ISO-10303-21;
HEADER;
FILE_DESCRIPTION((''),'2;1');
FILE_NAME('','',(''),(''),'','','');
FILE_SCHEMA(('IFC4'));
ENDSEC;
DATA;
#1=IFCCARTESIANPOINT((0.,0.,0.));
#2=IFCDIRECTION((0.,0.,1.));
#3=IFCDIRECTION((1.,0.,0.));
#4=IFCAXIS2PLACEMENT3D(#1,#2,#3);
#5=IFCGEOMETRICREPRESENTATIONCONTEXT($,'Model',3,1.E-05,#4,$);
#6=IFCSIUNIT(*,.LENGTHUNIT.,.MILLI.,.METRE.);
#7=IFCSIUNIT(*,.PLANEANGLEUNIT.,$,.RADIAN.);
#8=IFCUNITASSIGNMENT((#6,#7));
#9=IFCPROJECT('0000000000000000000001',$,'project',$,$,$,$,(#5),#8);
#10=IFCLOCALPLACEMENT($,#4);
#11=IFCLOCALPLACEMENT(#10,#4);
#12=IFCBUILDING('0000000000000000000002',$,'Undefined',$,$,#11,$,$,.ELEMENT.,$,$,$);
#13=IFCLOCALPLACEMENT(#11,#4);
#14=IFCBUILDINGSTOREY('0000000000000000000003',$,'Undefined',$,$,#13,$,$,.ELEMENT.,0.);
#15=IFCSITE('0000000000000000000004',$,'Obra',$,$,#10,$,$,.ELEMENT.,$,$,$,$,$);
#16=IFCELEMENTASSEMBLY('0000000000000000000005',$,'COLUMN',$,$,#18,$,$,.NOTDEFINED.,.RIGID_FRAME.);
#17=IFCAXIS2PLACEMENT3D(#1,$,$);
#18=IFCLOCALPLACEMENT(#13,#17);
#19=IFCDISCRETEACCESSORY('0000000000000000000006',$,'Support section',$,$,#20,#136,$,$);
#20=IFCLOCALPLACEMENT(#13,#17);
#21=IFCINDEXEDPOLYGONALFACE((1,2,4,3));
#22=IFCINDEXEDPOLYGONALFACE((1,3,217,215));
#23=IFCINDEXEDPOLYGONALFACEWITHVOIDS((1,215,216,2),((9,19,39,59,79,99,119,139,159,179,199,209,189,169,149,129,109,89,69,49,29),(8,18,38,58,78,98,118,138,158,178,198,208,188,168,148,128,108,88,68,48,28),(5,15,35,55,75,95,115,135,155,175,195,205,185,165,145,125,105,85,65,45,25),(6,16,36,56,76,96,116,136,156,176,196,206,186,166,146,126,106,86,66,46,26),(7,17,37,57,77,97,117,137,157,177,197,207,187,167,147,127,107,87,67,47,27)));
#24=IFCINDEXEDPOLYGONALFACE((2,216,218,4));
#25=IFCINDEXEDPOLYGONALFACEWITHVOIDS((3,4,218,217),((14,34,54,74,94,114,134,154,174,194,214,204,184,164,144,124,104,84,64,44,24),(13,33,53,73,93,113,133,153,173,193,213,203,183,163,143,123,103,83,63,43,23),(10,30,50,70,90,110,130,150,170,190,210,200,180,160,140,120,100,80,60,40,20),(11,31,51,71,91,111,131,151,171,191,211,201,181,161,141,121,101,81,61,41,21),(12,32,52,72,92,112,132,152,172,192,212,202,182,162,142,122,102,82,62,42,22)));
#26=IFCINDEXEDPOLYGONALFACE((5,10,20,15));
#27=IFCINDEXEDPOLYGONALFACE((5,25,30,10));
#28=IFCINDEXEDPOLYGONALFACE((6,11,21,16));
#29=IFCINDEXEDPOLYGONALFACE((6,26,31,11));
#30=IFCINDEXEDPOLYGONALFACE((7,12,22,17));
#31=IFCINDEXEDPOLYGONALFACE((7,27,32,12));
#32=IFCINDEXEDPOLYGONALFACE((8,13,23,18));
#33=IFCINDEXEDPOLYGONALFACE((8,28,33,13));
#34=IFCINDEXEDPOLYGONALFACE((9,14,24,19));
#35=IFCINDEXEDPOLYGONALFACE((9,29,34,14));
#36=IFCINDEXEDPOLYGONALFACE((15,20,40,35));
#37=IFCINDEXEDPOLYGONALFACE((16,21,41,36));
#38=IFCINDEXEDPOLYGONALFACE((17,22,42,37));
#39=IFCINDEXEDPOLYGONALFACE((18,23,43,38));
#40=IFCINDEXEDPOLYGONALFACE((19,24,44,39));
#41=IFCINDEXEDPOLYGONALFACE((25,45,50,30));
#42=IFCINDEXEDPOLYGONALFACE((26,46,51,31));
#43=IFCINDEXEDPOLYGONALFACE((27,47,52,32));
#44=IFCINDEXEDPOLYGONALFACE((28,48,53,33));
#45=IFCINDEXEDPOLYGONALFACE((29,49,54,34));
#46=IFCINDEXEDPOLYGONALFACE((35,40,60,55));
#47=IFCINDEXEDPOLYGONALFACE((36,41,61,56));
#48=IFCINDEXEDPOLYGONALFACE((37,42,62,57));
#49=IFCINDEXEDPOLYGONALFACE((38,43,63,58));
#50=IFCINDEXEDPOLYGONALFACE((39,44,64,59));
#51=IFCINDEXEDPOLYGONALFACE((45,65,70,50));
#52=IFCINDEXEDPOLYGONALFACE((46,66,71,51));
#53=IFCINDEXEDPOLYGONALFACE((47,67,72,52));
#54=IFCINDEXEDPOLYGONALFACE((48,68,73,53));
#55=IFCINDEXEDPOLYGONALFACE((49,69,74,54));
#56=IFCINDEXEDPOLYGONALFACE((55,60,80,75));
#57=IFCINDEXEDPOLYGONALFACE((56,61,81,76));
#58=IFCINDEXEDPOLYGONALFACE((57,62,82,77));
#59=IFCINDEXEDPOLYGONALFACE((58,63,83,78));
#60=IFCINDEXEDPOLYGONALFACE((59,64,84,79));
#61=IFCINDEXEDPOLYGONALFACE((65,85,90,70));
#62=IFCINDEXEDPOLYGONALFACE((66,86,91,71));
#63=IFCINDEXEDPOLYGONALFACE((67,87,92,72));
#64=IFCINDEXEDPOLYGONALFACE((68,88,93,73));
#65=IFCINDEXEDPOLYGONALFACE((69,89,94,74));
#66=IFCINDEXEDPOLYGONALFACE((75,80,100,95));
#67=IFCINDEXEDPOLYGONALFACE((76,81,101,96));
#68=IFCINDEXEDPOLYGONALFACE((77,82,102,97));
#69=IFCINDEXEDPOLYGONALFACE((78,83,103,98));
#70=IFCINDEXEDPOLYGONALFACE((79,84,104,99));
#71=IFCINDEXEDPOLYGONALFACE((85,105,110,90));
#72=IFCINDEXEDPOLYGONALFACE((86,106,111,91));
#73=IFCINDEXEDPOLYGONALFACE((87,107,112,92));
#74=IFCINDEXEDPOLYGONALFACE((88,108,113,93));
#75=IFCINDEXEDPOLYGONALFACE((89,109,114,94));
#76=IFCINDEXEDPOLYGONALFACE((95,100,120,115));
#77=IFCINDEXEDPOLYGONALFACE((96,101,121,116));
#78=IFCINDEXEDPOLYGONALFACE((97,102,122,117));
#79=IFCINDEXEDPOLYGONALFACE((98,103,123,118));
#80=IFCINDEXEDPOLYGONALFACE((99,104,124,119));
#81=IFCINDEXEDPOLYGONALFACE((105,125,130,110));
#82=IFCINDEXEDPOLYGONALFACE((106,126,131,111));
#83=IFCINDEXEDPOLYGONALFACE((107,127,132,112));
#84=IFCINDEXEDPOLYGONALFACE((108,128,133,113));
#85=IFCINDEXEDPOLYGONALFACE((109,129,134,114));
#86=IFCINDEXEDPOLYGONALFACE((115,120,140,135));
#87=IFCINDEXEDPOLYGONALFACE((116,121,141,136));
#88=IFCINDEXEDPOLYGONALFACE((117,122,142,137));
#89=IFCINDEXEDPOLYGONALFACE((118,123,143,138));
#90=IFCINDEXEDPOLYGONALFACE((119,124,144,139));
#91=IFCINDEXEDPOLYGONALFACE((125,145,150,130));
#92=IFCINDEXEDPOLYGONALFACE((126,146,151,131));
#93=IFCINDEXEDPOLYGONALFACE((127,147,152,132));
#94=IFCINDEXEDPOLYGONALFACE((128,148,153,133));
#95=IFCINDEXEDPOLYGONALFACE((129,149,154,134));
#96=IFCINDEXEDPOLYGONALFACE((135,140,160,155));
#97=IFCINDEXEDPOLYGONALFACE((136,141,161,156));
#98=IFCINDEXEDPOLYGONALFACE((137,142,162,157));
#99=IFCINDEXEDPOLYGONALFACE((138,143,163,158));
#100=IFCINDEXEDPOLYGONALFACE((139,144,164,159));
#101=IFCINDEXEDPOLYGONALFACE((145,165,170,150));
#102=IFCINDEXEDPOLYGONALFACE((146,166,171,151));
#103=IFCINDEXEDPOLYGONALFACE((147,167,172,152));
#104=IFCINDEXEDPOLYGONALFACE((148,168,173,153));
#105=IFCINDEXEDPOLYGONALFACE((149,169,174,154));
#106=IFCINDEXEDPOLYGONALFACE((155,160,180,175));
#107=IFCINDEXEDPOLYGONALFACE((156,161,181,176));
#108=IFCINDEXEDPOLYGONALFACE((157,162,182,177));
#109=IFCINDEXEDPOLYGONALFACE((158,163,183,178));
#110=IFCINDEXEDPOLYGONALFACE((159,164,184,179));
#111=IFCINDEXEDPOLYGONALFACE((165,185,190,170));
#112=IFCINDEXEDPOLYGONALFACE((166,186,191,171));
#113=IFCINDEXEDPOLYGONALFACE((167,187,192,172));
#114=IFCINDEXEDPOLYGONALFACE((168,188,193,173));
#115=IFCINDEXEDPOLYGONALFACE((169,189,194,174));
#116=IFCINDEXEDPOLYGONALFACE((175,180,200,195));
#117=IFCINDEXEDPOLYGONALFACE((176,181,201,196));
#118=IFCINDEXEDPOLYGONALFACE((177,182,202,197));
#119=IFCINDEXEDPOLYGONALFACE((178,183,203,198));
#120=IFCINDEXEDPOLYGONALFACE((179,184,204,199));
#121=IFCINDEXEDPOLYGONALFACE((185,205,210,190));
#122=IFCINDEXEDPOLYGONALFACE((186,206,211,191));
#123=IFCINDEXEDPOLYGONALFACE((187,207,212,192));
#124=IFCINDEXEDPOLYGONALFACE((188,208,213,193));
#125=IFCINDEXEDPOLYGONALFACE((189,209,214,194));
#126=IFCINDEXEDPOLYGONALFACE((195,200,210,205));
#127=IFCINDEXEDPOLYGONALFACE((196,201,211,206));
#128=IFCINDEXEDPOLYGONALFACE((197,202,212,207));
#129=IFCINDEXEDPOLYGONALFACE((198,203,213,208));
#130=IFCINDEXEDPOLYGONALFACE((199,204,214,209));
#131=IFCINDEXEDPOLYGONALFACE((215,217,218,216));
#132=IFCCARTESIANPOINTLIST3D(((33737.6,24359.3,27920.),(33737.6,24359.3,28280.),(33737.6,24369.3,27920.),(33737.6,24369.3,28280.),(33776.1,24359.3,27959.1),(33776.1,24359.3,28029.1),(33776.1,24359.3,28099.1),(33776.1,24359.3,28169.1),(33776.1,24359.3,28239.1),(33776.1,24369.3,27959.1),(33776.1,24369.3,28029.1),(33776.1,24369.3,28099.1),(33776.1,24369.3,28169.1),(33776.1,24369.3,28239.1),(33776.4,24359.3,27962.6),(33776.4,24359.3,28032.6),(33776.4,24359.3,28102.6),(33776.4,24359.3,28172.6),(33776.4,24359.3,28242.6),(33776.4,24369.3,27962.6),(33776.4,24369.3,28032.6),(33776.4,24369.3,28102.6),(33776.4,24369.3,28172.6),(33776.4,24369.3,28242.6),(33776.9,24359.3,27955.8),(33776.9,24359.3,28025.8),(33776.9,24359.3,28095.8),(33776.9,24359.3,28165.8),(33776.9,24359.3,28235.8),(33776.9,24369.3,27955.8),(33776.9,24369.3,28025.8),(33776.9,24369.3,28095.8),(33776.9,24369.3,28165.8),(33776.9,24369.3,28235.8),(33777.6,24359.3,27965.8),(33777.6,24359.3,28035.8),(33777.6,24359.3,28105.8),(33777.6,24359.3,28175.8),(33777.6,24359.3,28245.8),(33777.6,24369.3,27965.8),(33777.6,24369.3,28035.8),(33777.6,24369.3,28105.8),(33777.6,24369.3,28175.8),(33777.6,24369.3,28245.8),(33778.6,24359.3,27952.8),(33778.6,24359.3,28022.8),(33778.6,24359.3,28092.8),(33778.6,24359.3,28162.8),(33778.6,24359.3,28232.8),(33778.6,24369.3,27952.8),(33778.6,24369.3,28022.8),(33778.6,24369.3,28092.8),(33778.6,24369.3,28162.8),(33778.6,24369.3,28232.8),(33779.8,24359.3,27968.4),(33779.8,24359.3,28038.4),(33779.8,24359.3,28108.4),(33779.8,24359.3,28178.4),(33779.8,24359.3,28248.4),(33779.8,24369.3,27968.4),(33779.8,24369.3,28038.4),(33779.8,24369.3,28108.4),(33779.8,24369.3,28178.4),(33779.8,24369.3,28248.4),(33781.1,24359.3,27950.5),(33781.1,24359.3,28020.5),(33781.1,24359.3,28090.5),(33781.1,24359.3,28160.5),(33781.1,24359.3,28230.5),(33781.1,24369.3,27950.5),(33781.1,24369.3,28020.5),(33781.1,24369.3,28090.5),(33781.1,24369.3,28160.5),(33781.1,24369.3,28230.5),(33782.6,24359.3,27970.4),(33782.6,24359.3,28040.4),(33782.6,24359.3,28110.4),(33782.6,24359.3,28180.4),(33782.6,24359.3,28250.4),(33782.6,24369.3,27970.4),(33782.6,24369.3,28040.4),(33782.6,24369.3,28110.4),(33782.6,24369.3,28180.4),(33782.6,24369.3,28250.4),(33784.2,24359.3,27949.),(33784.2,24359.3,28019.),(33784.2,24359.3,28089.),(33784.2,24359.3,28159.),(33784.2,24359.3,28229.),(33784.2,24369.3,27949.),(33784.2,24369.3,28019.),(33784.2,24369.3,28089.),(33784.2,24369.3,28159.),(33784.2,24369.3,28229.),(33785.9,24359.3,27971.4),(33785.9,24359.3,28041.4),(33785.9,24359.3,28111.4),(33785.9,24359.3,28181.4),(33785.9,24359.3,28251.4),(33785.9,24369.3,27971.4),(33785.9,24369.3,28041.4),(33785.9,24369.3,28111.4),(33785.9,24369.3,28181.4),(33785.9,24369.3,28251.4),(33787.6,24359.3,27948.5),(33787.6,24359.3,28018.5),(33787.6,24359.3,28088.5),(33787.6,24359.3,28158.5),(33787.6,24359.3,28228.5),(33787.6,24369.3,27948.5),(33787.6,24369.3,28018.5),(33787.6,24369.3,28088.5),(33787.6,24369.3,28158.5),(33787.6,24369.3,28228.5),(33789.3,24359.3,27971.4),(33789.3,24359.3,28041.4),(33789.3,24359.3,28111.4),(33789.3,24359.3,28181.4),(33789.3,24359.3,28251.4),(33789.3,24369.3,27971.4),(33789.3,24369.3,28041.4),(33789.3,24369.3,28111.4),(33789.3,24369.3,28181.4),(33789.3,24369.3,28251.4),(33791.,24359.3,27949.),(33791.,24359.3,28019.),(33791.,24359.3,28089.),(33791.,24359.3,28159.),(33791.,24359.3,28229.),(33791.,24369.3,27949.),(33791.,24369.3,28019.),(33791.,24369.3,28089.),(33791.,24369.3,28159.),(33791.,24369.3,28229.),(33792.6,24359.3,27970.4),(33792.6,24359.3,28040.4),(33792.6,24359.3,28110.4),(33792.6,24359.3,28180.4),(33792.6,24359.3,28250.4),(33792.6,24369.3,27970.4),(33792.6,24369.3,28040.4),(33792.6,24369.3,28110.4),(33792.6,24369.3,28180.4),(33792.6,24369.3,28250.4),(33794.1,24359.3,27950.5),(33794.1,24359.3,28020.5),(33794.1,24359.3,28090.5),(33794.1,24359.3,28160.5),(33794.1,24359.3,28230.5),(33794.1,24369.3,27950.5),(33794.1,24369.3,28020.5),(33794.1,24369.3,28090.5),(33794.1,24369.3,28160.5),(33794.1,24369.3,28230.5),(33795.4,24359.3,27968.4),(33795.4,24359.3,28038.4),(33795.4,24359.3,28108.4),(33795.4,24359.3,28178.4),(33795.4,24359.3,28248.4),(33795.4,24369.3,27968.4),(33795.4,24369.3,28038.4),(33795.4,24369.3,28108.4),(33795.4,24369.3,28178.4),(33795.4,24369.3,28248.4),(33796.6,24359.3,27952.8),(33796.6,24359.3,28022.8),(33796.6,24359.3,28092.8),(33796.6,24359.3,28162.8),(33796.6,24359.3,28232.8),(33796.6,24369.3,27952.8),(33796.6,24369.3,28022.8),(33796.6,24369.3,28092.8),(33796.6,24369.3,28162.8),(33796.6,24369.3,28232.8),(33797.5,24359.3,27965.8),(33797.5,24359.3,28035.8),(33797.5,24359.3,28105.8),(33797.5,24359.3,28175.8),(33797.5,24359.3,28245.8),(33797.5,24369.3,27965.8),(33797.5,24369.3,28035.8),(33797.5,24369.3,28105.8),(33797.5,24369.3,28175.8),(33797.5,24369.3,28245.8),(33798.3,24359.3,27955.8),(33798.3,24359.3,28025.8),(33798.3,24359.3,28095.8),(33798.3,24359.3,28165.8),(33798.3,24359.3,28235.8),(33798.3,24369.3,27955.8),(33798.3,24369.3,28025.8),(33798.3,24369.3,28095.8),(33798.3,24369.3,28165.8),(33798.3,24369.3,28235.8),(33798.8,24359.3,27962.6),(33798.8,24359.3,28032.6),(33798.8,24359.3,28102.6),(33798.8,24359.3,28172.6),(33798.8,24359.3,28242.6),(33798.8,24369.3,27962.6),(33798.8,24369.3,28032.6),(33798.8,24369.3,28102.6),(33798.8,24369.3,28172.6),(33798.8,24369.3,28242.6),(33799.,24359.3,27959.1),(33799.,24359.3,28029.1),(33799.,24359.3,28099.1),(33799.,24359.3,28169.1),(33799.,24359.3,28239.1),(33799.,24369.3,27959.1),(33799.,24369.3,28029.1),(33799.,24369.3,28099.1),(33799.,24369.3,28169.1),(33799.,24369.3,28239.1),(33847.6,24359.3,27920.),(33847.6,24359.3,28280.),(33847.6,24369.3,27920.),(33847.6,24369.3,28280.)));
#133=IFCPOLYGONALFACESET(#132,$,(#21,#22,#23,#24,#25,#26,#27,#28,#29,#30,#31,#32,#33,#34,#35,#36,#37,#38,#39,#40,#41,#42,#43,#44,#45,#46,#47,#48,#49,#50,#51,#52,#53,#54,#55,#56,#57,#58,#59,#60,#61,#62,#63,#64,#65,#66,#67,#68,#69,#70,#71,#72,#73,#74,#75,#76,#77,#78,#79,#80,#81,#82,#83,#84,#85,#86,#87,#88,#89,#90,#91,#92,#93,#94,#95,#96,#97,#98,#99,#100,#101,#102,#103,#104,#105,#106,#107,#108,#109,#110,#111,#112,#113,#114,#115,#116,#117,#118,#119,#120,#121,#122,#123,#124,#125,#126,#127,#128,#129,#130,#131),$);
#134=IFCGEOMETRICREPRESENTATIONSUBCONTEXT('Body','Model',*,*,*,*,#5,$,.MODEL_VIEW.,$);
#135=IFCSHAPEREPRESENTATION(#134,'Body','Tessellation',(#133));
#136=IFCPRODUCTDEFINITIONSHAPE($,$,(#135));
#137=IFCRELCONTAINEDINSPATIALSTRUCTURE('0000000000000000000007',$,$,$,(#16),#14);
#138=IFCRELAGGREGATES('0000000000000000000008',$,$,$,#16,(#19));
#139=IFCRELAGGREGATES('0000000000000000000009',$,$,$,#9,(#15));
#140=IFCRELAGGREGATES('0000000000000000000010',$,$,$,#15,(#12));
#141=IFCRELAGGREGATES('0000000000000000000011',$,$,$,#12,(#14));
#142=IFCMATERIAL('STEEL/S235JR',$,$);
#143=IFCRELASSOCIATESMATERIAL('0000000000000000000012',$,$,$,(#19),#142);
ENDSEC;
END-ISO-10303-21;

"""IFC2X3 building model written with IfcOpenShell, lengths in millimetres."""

from ifc_helpers import new_model, si_unit, frame, origin_with_axes, origin_2d_with_axis, place, context, subcontext, project, spatial, rectangle, circle, extrude, source, transform, mapped, material, element, aggregate, save


model = new_model("IFC2X3")

# Units and contexts
model_context = context("Model", 3, precision=1e-05, world=origin_with_axes())
body_context = subcontext(model_context, "Body", "Model", "MODEL_VIEW")
ifc_project = project(units=[si_unit("LENGTHUNIT", "METRE", prefix="MILLI"), si_unit("PLANEANGLEUNIT", "RADIAN")], contexts=[model_context])

# Site, building, storey
site_placement = place(None, origin_with_axes())
site = spatial("IfcSite", under=ifc_project, at=site_placement, Name="Obra", CompositionType="ELEMENT")
building_placement = place(site_placement, origin_with_axes())
building = spatial("IfcBuilding", under=site, at=building_placement, Name="Undefined", CompositionType="ELEMENT")
storey_placement = place(building_placement, origin_with_axes())
storey = spatial("IfcBuildingStorey", under=building, at=storey_placement, Name="Undefined", CompositionType="ELEMENT", Elevation=0.0)

# Element assembly
assembly_1_placement = place(storey_placement, origin_with_axes())
assembly_1 = element("IfcElementAssembly", 1, at=assembly_1_placement, inside=storey, Name="COLUMN", AssemblyPlace="NOTDEFINED", PredefinedType="RIGID_FRAME")
ifc_material_1 = material(Name="STEEL/S235JR")

# Shared definitions
shared_shape_1 = source(origin_with_axes(), body_context, "Body", "SweptSolid", [
    extrude(circle(Radius=11.5, at=origin_2d_with_axis()), frame((0.0, -14.4, 0.0), z_axis=(0.0, 1.0, 0.0), x_axis=(1.0, 0.0, 0.0)), (0.0, 0.0, 1.0), 10.2),
])

# Discrete accessory, opening
discrete_accessory_1_placement = place(assembly_1_placement, frame((33792.6, 24364.3, 27920.0), z_axis=(0.0, 0.0, 1.0), x_axis=(1.0, 0.0, 0.0)))
discrete_accessory_1 = element("IfcDiscreteAccessory", 2, at=discrete_accessory_1_placement, material=ifc_material_1, Name="Support section", context=body_context, shape_type="SweptSolid", body=[
    extrude(rectangle(XDim=10.0, YDim=110.0, at=origin_2d_with_axis()), frame((0.0, 0.0, 360.0), z_axis=(0.0, 0.0, -1.0), x_axis=(0.0, 1.0, 0.0)), (0.0, 0.0, 1.0), 360.0),
])
opening_1_placement = place(assembly_1_placement, frame((33837.6, 24355.0, 28300.0), z_axis=(-1.0, 0.0, 0.0), x_axis=(0.0, 0.0, -1.0)))
element("IfcOpeningElement", 3, at=opening_1_placement, cuts=discrete_accessory_1, ObjectType="Opening", context=body_context, shape_type="MappedRepresentation", body=[
    mapped(shared_shape_1, transform((60.0, 0.0, 50.0))),
    mapped(shared_shape_1, transform((130.0, 0.0, 50.0))),
    mapped(shared_shape_1, transform((200.0, 0.0, 50.0))),
    mapped(shared_shape_1, transform((270.0, 0.0, 50.0))),
    mapped(shared_shape_1, transform((340.0, 0.0, 50.0))),
])
aggregate(assembly_1, [discrete_accessory_1])

save(model, "model.ifc")
